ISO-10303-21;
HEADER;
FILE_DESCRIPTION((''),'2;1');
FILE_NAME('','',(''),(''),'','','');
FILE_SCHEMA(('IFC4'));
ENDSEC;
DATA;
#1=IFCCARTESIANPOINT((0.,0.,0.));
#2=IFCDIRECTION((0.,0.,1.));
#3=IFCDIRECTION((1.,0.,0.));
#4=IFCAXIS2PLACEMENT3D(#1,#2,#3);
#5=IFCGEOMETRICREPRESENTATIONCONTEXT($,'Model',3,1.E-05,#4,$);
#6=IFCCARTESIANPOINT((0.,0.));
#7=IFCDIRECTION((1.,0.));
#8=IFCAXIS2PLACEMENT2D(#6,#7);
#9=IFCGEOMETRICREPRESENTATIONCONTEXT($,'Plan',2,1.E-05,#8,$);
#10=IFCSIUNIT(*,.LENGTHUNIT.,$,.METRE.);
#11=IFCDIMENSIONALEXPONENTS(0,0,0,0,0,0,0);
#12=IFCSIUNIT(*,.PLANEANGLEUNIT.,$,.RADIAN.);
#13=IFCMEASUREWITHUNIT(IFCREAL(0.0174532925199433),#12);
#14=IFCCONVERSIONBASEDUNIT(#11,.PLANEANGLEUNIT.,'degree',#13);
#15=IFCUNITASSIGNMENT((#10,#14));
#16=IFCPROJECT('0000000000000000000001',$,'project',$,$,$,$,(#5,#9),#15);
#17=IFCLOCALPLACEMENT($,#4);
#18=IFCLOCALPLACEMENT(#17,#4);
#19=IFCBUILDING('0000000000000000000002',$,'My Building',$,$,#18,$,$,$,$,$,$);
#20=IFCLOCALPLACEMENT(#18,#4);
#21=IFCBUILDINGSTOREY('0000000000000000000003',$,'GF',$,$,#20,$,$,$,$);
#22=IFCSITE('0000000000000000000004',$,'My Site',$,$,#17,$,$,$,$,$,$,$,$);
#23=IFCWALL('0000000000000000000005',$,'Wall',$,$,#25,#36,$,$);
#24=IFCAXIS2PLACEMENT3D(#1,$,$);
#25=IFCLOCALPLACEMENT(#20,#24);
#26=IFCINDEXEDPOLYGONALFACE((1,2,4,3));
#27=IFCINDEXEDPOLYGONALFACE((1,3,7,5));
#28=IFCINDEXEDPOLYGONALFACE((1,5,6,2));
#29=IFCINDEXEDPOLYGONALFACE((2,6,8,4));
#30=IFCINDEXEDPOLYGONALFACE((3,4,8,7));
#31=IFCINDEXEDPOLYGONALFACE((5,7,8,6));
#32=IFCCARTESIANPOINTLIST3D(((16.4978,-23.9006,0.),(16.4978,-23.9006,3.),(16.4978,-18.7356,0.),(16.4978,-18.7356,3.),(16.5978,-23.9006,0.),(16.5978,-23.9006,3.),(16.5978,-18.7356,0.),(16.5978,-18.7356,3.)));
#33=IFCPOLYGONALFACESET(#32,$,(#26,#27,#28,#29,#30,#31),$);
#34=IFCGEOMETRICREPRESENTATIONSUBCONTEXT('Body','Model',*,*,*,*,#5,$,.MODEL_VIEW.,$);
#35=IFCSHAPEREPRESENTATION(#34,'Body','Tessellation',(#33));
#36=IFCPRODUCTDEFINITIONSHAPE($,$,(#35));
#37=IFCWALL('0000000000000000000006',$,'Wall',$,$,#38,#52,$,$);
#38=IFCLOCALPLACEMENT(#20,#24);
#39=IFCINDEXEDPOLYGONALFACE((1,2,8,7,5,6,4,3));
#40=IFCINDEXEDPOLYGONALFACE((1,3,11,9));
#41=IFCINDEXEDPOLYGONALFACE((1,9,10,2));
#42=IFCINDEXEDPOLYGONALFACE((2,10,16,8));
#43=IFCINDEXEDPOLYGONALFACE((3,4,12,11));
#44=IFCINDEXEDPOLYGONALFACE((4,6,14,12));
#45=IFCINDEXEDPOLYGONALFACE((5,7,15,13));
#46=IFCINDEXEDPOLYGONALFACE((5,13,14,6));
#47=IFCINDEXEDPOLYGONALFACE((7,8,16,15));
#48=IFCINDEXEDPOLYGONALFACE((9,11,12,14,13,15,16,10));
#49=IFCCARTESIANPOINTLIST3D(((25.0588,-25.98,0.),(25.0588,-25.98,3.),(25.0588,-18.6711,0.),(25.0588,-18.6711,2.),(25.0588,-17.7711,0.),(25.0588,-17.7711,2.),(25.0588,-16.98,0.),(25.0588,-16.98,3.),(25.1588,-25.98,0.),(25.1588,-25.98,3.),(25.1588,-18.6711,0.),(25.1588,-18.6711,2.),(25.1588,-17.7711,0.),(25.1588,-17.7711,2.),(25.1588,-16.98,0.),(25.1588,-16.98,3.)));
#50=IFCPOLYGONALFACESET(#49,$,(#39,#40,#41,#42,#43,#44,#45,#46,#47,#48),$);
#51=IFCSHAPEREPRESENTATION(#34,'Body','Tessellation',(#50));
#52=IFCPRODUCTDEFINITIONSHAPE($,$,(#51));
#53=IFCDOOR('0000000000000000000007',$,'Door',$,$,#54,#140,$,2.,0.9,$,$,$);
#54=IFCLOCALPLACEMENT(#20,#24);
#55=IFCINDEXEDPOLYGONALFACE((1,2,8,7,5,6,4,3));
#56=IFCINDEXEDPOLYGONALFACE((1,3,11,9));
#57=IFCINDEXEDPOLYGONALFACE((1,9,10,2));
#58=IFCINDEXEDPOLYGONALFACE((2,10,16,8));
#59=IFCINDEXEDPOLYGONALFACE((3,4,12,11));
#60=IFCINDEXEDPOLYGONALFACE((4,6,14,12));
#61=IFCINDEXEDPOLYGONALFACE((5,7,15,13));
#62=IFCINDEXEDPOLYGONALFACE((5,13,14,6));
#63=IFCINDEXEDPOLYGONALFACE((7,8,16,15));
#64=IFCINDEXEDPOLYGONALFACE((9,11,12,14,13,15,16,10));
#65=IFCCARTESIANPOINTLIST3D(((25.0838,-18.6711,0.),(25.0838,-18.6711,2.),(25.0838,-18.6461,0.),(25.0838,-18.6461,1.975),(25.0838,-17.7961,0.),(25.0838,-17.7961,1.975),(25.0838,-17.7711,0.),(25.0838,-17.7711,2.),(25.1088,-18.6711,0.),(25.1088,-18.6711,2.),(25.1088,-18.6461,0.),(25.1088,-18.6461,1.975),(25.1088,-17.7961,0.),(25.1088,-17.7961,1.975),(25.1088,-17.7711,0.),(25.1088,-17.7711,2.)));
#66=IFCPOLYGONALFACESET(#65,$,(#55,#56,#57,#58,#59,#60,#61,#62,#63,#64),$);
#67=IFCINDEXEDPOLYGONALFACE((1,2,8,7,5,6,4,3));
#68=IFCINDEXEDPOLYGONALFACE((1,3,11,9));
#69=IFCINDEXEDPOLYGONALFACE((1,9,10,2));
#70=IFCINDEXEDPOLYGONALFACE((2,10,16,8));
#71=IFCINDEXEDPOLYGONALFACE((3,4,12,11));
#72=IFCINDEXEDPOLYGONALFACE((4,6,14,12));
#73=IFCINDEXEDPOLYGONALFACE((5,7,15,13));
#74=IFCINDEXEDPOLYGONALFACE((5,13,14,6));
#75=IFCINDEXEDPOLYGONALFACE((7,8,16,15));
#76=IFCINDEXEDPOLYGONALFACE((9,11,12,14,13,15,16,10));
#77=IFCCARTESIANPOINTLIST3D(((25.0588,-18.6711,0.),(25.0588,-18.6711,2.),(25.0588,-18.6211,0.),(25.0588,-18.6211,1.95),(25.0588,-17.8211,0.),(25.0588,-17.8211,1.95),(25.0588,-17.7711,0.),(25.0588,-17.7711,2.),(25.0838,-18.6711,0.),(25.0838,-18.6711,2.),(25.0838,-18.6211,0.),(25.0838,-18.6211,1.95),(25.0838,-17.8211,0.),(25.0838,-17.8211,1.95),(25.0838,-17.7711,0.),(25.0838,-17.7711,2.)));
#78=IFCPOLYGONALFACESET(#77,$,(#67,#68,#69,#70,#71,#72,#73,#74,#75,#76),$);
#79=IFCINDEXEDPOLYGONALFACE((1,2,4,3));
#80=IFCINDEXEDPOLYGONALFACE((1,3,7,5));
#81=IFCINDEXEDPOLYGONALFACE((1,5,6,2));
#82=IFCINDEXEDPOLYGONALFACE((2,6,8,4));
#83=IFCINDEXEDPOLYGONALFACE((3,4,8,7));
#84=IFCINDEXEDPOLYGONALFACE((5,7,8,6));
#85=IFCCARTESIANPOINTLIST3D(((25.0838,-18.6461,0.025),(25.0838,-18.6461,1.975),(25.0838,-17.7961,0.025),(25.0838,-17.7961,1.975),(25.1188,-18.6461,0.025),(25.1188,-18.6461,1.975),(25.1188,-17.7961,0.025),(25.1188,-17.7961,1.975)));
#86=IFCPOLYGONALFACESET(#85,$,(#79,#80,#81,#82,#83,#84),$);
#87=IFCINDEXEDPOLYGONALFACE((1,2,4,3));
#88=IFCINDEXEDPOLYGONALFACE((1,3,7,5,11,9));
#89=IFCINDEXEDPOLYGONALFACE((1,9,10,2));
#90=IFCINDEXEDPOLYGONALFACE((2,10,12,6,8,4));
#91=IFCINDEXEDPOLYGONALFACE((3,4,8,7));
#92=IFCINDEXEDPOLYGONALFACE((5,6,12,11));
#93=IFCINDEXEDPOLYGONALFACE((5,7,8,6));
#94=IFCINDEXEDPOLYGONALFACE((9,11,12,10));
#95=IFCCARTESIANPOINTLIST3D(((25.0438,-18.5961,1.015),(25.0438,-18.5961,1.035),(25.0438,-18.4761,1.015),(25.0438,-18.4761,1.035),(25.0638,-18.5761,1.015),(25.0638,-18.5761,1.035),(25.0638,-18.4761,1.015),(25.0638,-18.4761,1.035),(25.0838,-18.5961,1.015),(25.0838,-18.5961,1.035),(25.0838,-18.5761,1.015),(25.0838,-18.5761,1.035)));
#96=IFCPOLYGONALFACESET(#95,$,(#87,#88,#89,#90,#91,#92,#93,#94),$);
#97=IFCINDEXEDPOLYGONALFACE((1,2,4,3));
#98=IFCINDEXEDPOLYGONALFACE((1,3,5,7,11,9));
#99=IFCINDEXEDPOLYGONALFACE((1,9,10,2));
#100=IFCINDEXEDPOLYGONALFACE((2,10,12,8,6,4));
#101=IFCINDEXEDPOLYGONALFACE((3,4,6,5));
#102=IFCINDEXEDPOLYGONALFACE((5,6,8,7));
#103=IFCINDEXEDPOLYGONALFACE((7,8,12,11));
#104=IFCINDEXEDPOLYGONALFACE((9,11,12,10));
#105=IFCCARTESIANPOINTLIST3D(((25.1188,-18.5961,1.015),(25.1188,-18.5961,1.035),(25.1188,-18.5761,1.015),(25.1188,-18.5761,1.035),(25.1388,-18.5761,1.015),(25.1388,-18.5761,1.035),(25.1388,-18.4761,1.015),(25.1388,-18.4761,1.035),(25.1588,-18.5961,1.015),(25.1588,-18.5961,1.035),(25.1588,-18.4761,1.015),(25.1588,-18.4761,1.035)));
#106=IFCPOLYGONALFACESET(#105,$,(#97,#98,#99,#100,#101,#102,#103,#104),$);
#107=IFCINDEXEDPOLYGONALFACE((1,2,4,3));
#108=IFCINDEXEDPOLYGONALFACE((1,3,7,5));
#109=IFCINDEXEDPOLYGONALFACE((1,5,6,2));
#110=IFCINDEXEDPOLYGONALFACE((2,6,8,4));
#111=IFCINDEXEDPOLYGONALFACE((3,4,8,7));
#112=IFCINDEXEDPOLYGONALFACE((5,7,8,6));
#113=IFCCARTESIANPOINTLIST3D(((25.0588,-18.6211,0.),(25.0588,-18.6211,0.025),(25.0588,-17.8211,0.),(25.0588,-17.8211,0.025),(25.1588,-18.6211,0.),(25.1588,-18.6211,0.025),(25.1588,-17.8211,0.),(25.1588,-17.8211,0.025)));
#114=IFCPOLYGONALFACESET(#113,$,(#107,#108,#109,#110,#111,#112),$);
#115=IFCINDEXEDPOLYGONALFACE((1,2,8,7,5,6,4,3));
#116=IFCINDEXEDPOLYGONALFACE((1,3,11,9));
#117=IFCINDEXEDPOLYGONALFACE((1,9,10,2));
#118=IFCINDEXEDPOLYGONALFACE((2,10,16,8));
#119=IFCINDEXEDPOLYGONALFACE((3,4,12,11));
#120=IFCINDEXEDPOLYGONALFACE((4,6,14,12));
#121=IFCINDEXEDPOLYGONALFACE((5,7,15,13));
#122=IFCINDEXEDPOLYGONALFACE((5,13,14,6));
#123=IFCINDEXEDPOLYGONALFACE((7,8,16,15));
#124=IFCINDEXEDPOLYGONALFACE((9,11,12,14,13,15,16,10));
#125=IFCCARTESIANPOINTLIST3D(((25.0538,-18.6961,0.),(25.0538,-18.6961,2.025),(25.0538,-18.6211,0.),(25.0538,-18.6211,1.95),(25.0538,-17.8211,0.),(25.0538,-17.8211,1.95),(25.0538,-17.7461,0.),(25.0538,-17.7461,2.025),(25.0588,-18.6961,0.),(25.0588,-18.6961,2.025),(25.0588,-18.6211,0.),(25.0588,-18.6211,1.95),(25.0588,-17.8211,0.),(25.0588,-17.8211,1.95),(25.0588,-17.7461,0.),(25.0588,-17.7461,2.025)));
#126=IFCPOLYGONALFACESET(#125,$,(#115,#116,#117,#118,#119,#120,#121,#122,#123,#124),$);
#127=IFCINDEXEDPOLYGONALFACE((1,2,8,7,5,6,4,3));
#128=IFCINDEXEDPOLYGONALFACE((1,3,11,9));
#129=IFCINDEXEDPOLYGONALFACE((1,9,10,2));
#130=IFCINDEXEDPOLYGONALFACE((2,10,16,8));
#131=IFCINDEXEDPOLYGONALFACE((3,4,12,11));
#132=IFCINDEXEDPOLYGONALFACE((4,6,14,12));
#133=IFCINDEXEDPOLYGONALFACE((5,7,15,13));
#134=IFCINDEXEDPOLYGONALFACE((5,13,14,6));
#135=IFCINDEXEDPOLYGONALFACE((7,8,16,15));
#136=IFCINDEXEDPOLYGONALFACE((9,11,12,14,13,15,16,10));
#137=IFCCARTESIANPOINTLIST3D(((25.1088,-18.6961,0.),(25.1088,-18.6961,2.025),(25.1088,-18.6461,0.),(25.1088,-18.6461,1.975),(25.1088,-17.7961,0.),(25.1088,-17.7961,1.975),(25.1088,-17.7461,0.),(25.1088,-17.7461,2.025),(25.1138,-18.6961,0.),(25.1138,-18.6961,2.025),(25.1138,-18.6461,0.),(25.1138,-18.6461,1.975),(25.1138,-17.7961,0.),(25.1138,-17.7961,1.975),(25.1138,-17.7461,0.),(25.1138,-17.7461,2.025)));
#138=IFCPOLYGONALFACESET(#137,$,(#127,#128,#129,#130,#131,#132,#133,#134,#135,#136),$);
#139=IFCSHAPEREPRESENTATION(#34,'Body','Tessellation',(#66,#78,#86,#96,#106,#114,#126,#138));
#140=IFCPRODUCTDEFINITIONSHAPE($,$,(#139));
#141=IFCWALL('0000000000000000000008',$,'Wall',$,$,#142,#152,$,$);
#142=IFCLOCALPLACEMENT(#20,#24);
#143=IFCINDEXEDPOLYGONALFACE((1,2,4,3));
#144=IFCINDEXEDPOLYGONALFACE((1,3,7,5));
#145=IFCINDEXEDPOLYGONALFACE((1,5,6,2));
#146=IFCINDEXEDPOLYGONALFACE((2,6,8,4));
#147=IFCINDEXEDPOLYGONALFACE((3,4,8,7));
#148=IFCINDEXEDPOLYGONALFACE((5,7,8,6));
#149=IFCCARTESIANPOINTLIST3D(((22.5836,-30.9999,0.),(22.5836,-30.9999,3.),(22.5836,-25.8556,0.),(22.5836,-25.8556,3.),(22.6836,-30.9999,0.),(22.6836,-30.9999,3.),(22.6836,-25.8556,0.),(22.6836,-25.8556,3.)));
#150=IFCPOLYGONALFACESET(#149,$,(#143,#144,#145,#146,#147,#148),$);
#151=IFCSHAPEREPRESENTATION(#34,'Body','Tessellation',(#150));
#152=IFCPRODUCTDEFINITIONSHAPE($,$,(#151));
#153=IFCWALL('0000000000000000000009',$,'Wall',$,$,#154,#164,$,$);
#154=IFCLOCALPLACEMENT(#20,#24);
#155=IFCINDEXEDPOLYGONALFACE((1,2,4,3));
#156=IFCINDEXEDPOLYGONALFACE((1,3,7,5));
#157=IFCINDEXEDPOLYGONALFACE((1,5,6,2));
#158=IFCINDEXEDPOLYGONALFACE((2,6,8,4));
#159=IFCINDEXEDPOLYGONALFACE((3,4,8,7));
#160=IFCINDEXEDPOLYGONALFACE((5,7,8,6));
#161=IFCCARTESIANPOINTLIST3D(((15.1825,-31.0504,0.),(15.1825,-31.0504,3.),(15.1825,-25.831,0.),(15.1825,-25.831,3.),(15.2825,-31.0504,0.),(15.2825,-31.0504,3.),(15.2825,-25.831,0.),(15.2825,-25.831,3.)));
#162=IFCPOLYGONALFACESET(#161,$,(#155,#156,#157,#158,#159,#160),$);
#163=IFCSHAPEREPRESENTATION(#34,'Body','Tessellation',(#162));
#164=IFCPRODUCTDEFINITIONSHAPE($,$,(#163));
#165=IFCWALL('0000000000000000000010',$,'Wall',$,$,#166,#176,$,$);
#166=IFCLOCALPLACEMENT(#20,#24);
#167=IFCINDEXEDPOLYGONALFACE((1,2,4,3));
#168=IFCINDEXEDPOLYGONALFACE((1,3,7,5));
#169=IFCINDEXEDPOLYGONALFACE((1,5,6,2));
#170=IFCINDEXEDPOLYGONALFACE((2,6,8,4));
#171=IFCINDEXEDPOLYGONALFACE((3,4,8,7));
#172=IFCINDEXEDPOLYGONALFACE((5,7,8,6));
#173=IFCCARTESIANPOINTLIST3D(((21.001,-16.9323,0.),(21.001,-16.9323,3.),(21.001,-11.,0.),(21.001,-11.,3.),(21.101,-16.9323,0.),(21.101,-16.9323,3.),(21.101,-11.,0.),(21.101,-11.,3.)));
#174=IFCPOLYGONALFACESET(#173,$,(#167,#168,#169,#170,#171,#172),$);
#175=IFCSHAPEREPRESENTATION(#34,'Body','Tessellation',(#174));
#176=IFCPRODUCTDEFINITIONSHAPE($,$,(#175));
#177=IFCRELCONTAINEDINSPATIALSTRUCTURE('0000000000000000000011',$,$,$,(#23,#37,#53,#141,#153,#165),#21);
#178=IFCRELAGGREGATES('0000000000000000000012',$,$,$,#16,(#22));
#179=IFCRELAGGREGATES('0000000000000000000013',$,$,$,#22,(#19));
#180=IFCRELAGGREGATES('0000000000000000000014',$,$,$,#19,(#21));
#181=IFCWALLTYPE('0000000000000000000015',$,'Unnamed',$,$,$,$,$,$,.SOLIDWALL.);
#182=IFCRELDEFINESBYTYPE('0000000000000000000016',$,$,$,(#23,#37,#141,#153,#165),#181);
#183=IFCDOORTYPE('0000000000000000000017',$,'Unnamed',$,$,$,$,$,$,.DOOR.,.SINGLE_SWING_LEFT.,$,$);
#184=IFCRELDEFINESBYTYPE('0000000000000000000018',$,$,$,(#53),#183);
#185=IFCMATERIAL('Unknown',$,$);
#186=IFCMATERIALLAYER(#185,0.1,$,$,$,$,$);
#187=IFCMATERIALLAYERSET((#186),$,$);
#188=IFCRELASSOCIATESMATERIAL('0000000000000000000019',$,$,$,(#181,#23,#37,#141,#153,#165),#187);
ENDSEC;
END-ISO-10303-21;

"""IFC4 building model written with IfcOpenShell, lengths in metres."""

from ifc_helpers import new_model, entity, si_unit, converted_unit, frame, origin_with_axes, origin_2d_with_axis, place, context, subcontext, project, spatial, line, indexed_curve, outline, extrude, shape, source, transform, mapped, material, layer, layer_set, layer_usage, type_object, type_shapes, element, fill, save


model = new_model("IFC4")

# Units and contexts
model_context = context("Model", 3, precision=1e-05, world=origin_with_axes())
plan_context = context("Plan", 2, precision=1e-05, world=origin_2d_with_axis())
body_context_1 = subcontext(model_context, "Body", "Model", "MODEL_VIEW")
body_context_2 = subcontext(plan_context, "Body", "Plan", "PLAN_VIEW")
ifc_project = project(units=[si_unit("LENGTHUNIT", "METRE"), converted_unit("PLANEANGLEUNIT", "degree", entity("IfcReal", 0.0174532925199433), si_unit("PLANEANGLEUNIT", "RADIAN"), dimensions=[0, 0, 0, 0, 0, 0, 0])], contexts=[model_context, plan_context])

# Site, building, storey
site_placement = place(None, origin_with_axes())
site = spatial("IfcSite", under=ifc_project, at=site_placement, Name="My Site")
building_placement = place(site_placement, origin_with_axes())
building = spatial("IfcBuilding", under=site, at=building_placement, Name="My Building")
storey_placement = place(building_placement, origin_with_axes())
storey = spatial("IfcBuildingStorey", under=building, at=storey_placement, Name="GF")

# Shared definitions
ifc_material = material(Name="Unknown")
ifc_layer = layer(ifc_material, 0.1)
ifc_layer_set = layer_set([ifc_layer])
wall_type = type_object("IfcWallType", Name="Unnamed", PredefinedType="SOLIDWALL", material=ifc_layer_set)

# Shared definitions
shared_shape_1 = source(origin_with_axes(), body_context_1, "Body", "SweptSolid", [
    extrude(outline(indexed_curve([(0.0, 0.0), (0.9, 0.0), (0.9, 2.0), (0.0, 2.0)], segments=[line(1, 2, 3, 4, 1)])), frame((0.0, -0.6, 0.0), z_axis=(0.0, -1.0, 0.0), x_axis=(1.0, 0.0, 0.0)), (0.0, 0.0, -1.0), 1.2),
])
door_type = type_object("IfcDoorType", Name="Unnamed", OperationType="SINGLE_SWING_LEFT", PredefinedType="DOOR")
shared_shape_2 = source(origin_with_axes(), body_context_1, "Body", "SweptSolid", [
    extrude(outline(indexed_curve([(0.0, 0.0), (0.0, 2.0), (0.9, 2.0), (0.9, 0.0), (0.875, 0.0), (0.875, 1.975), (0.025, 1.975), (0.025, 0.0)], segments=[line(1, 2, 3, 4, 5, 6, 7, 8, 1)])), frame((0.0, 0.025, 0.0), z_axis=(0.0, -1.0, 0.0), x_axis=(1.0, 0.0, 0.0)), (0.0, 0.0, -1.0), 0.025),
    extrude(outline(indexed_curve([(0.0, 0.0), (0.0, 2.0), (0.9, 2.0), (0.9, 0.0), (0.85, 0.0), (0.85, 1.95), (0.05, 1.95), (0.05, 0.0)], segments=[line(1, 2, 3, 4, 5, 6, 7, 8, 1)])), frame((0.0, 0.0, 0.0), z_axis=(0.0, -1.0, 0.0), x_axis=(1.0, 0.0, 0.0)), (0.0, 0.0, -1.0), 0.025),
    extrude(outline(indexed_curve([(0.0, 0.0), (0.85, 0.0), (0.85, 0.035), (0.0, 0.035)], segments=[line(1, 2, 3, 4, 1)])), frame((0.025, 0.025, 0.025), z_axis=(0.0, 0.0, 1.0), x_axis=(1.0, 0.0, 0.0)), (0.0, 0.0, 1.0), 1.95),
    extrude(outline(indexed_curve([(0.0, 0.0), (0.0, -0.04), (-0.12, -0.04), (-0.12, -0.02), (-0.02, -0.02), (-0.02, 0.0)], segments=[line(1, 2, 3, 4, 5, 6, 1)])), frame((0.825, 0.025, 1.015), z_axis=(0.0, 0.0, 1.0), x_axis=(1.0, 0.0, 0.0)), (0.0, 0.0, 1.0), 0.02),
    extrude(outline(indexed_curve([(0.0, 0.0), (0.0, 0.04), (-0.12, 0.04), (-0.12, 0.02), (-0.02, 0.02), (-0.02, 0.0)], segments=[line(1, 2, 3, 4, 5, 6, 1)])), frame((0.825, 0.06, 1.015), z_axis=(0.0, 0.0, 1.0), x_axis=(1.0, 0.0, 0.0)), (0.0, 0.0, 1.0), 0.02),
    extrude(outline(indexed_curve([(0.0, 0.0), (0.8, 0.0), (0.8, 0.1), (0.0, 0.1)], segments=[line(1, 2, 3, 4, 1)])), frame((0.05, 0.0, 0.0), z_axis=(0.0, 0.0, 1.0), x_axis=(1.0, 0.0, 0.0)), (0.0, 0.0, 1.0), 0.025),
    extrude(outline(indexed_curve([(0.0, 0.0), (0.0, 2.025), (0.95, 2.025), (0.95, 0.0), (0.875, 0.0), (0.875, 1.95), (0.075, 1.95), (0.075, 0.0)], segments=[line(1, 2, 3, 4, 5, 6, 7, 8, 1)])), frame((-0.025, -0.005, 0.0), z_axis=(0.0, -1.0, 0.0), x_axis=(1.0, 0.0, 0.0)), (0.0, 0.0, -1.0), 0.005),
    extrude(outline(indexed_curve([(0.0, 0.0), (0.0, 2.025), (0.95, 2.025), (0.95, 0.0), (0.9, 0.0), (0.9, 1.975), (0.05, 1.975), (0.05, 0.0)], segments=[line(1, 2, 3, 4, 5, 6, 7, 8, 1)])), frame((-0.025, 0.05, 0.0), z_axis=(0.0, -1.0, 0.0), x_axis=(1.0, 0.0, 0.0)), (0.0, 0.0, -1.0), 0.005),
])
shared_shape_3 = source(origin_with_axes(), body_context_2, "Body", "Curve2D", [
    entity("IfcIndexedPolyCurve", entity("IfcCartesianPointList2D", [[0.0, 0.0], [0.0, 0.05], [0.025, 0.05], [0.025, 0.025], [0.05, 0.025], [0.05, 0.0]]), [entity("IfcLineIndex", [1, 2, 3, 4, 5, 6, 1])]),
    entity("IfcIndexedPolyCurve", entity("IfcCartesianPointList2D", [[0.9, 0.0], [0.9, 0.05], [0.875, 0.05], [0.875, 0.025], [0.85, 0.025], [0.85, 0.0]]), [entity("IfcLineIndex", [1, 2, 3, 4, 5, 6, 1])]),
    entity("IfcTrimmedCurve", entity("IfcEllipse", entity("IfcAxis2Placement2D", entity("IfcCartesianPoint", [0.06, 0.05]), entity("IfcDirection", [1.0, 0.0])), 0.815, 0.85), [entity("IfcCartesianPoint", [0.875, 0.05])], [entity("IfcCartesianPoint", [0.06, 0.9])], True, "CARTESIAN"),
    entity("IfcIndexedPolyCurve", entity("IfcCartesianPointList2D", [[0.025, 0.05], [0.06, 0.05], [0.06, 0.9], [0.025, 0.9]]), [entity("IfcLineIndex", [1, 2, 3, 4, 1])]),
])
type_shapes(door_type, [shared_shape_2, shared_shape_3])

# Wall
ifc_layer_usage_1 = layer_usage(ifc_layer_set, "AXIS2", "POSITIVE", 0.0)
wall_1_placement = place(storey_placement, frame((16.4978, -18.7356, 0.0), z_axis=(0.0, 0.0, 1.0), x_axis=(0.0, -1.0, 0.0)))
element("IfcWall", 1, at=wall_1_placement, inside=storey, type_object=wall_type, material=ifc_layer_usage_1, Name="Wall", context=body_context_1, shape_type="SweptSolid", body=[
    extrude(outline(indexed_curve([(0.0, 0.0), (0.0, 0.1), (5.1651, 0.1), (5.1651, 0.0)], segments=[line(1, 2, 3, 4, 1)])), origin_with_axes(), (0.0, 0.0, 1.0), 3.0),
])

# Wall, opening, door
ifc_layer_usage_2 = layer_usage(ifc_layer_set, "AXIS2", "POSITIVE", 0.0)
wall_2_placement = place(storey_placement, frame((25.0588, -16.98, 0.0), z_axis=(0.0, 0.0, 1.0), x_axis=(0.0, -1.0, 0.0)))
wall_2 = element("IfcWall", 2, at=wall_2_placement, inside=storey, type_object=wall_type, material=ifc_layer_usage_2, Name="Wall", context=body_context_1, shape_type="SweptSolid", body=[
    extrude(outline(indexed_curve([(0.0, 0.0), (0.0, 0.1), (9.0, 0.1), (9.0, 0.0)], segments=[line(1, 2, 3, 4, 1)])), origin_with_axes(), (0.0, 0.0, 1.0), 3.0),
])
opening_1_placement = place(wall_2_placement, frame((0.7911, 0.0, 0.0), z_axis=(0.0, 0.0, 1.0), x_axis=(1.0, 0.0, 0.0)))
opening_1 = element("IfcOpeningElement", 3, at=opening_1_placement, cuts=wall_2, PredefinedType="OPENING", context=body_context_1, shape_type="MappedRepresentation", body=[
    mapped(shared_shape_1, transform((0.0, 0.0, 0.0), x_axis=(1.0, 0.0, 0.0), y_axis=(0.0, 1.0, 0.0), z_axis=(0.0, 0.0, 1.0), scale=1.0)),
])
door_1_placement = place(opening_1_placement, frame((0.0, 0.0, 0.0), z_axis=(0.0, 0.0, 1.0), x_axis=(1.0, 0.0, 0.0)))
door_1 = element("IfcDoor", 4, at=door_1_placement, inside=storey, type_object=door_type, Name="Door", OverallHeight=2.0, OverallWidth=0.9, shapes=[
    shape(body_context_1, "Body", "MappedRepresentation", [mapped(shared_shape_2, transform((0.0, 0.0, 0.0), x_axis=(1.0, 0.0, 0.0), y_axis=(0.0, 1.0, 0.0), z_axis=(0.0, 0.0, 1.0), scale=1.0))]),
    shape(body_context_2, "Body", "MappedRepresentation", [mapped(shared_shape_3, transform((0.0, 0.0, 0.0), x_axis=(1.0, 0.0, 0.0), y_axis=(0.0, 1.0, 0.0), z_axis=(0.0, 0.0, 1.0), scale=1.0))]),
])
fill(opening_1, door_1)

# Walls
ifc_layer_usage_3 = layer_usage(ifc_layer_set, "AXIS2", "POSITIVE", 0.0)
wall_3_placement = place(storey_placement, frame((22.5836, -25.8556, 0.0), z_axis=(0.0, 0.0, 1.0), x_axis=(0.0, -1.0, 0.0)))
element("IfcWall", 5, at=wall_3_placement, inside=storey, type_object=wall_type, material=ifc_layer_usage_3, Name="Wall", context=body_context_1, shape_type="SweptSolid", body=[
    extrude(outline(indexed_curve([(0.0, 0.0), (0.0, 0.1), (5.1443, 0.1), (5.1443, 0.0)], segments=[line(1, 2, 3, 4, 1)])), origin_with_axes(), (0.0, 0.0, 1.0), 3.0),
])
ifc_layer_usage_4 = layer_usage(ifc_layer_set, "AXIS2", "POSITIVE", 0.0)
wall_4_placement = place(storey_placement, frame((15.1825, -25.831, 0.0), z_axis=(0.0, 0.0, 1.0), x_axis=(0.0, -1.0, 0.0)))
element("IfcWall", 6, at=wall_4_placement, inside=storey, type_object=wall_type, material=ifc_layer_usage_4, Name="Wall", context=body_context_1, shape_type="SweptSolid", body=[
    extrude(outline(indexed_curve([(0.0, 0.0), (0.0, 0.1), (5.2194, 0.1), (5.2194, 0.0)], segments=[line(1, 2, 3, 4, 1)])), origin_with_axes(), (0.0, 0.0, 1.0), 3.0),
])
ifc_layer_usage_5 = layer_usage(ifc_layer_set, "AXIS2", "POSITIVE", 0.0)
wall_5_placement = place(storey_placement, frame((21.101, -16.9323, 0.0), z_axis=(0.0, 0.0, 1.0), x_axis=(0.0, 1.0, 0.0)))
element("IfcWall", 7, at=wall_5_placement, inside=storey, type_object=wall_type, material=ifc_layer_usage_5, Name="Wall", context=body_context_1, shape_type="SweptSolid", body=[
    extrude(outline(indexed_curve([(0.0, 0.0), (0.0, 0.1), (5.9323, 0.1), (5.9323, 0.0)], segments=[line(1, 2, 3, 4, 1)])), origin_with_axes(), (0.0, 0.0, 1.0), 3.0),
])

save(model, "model.ifc")
